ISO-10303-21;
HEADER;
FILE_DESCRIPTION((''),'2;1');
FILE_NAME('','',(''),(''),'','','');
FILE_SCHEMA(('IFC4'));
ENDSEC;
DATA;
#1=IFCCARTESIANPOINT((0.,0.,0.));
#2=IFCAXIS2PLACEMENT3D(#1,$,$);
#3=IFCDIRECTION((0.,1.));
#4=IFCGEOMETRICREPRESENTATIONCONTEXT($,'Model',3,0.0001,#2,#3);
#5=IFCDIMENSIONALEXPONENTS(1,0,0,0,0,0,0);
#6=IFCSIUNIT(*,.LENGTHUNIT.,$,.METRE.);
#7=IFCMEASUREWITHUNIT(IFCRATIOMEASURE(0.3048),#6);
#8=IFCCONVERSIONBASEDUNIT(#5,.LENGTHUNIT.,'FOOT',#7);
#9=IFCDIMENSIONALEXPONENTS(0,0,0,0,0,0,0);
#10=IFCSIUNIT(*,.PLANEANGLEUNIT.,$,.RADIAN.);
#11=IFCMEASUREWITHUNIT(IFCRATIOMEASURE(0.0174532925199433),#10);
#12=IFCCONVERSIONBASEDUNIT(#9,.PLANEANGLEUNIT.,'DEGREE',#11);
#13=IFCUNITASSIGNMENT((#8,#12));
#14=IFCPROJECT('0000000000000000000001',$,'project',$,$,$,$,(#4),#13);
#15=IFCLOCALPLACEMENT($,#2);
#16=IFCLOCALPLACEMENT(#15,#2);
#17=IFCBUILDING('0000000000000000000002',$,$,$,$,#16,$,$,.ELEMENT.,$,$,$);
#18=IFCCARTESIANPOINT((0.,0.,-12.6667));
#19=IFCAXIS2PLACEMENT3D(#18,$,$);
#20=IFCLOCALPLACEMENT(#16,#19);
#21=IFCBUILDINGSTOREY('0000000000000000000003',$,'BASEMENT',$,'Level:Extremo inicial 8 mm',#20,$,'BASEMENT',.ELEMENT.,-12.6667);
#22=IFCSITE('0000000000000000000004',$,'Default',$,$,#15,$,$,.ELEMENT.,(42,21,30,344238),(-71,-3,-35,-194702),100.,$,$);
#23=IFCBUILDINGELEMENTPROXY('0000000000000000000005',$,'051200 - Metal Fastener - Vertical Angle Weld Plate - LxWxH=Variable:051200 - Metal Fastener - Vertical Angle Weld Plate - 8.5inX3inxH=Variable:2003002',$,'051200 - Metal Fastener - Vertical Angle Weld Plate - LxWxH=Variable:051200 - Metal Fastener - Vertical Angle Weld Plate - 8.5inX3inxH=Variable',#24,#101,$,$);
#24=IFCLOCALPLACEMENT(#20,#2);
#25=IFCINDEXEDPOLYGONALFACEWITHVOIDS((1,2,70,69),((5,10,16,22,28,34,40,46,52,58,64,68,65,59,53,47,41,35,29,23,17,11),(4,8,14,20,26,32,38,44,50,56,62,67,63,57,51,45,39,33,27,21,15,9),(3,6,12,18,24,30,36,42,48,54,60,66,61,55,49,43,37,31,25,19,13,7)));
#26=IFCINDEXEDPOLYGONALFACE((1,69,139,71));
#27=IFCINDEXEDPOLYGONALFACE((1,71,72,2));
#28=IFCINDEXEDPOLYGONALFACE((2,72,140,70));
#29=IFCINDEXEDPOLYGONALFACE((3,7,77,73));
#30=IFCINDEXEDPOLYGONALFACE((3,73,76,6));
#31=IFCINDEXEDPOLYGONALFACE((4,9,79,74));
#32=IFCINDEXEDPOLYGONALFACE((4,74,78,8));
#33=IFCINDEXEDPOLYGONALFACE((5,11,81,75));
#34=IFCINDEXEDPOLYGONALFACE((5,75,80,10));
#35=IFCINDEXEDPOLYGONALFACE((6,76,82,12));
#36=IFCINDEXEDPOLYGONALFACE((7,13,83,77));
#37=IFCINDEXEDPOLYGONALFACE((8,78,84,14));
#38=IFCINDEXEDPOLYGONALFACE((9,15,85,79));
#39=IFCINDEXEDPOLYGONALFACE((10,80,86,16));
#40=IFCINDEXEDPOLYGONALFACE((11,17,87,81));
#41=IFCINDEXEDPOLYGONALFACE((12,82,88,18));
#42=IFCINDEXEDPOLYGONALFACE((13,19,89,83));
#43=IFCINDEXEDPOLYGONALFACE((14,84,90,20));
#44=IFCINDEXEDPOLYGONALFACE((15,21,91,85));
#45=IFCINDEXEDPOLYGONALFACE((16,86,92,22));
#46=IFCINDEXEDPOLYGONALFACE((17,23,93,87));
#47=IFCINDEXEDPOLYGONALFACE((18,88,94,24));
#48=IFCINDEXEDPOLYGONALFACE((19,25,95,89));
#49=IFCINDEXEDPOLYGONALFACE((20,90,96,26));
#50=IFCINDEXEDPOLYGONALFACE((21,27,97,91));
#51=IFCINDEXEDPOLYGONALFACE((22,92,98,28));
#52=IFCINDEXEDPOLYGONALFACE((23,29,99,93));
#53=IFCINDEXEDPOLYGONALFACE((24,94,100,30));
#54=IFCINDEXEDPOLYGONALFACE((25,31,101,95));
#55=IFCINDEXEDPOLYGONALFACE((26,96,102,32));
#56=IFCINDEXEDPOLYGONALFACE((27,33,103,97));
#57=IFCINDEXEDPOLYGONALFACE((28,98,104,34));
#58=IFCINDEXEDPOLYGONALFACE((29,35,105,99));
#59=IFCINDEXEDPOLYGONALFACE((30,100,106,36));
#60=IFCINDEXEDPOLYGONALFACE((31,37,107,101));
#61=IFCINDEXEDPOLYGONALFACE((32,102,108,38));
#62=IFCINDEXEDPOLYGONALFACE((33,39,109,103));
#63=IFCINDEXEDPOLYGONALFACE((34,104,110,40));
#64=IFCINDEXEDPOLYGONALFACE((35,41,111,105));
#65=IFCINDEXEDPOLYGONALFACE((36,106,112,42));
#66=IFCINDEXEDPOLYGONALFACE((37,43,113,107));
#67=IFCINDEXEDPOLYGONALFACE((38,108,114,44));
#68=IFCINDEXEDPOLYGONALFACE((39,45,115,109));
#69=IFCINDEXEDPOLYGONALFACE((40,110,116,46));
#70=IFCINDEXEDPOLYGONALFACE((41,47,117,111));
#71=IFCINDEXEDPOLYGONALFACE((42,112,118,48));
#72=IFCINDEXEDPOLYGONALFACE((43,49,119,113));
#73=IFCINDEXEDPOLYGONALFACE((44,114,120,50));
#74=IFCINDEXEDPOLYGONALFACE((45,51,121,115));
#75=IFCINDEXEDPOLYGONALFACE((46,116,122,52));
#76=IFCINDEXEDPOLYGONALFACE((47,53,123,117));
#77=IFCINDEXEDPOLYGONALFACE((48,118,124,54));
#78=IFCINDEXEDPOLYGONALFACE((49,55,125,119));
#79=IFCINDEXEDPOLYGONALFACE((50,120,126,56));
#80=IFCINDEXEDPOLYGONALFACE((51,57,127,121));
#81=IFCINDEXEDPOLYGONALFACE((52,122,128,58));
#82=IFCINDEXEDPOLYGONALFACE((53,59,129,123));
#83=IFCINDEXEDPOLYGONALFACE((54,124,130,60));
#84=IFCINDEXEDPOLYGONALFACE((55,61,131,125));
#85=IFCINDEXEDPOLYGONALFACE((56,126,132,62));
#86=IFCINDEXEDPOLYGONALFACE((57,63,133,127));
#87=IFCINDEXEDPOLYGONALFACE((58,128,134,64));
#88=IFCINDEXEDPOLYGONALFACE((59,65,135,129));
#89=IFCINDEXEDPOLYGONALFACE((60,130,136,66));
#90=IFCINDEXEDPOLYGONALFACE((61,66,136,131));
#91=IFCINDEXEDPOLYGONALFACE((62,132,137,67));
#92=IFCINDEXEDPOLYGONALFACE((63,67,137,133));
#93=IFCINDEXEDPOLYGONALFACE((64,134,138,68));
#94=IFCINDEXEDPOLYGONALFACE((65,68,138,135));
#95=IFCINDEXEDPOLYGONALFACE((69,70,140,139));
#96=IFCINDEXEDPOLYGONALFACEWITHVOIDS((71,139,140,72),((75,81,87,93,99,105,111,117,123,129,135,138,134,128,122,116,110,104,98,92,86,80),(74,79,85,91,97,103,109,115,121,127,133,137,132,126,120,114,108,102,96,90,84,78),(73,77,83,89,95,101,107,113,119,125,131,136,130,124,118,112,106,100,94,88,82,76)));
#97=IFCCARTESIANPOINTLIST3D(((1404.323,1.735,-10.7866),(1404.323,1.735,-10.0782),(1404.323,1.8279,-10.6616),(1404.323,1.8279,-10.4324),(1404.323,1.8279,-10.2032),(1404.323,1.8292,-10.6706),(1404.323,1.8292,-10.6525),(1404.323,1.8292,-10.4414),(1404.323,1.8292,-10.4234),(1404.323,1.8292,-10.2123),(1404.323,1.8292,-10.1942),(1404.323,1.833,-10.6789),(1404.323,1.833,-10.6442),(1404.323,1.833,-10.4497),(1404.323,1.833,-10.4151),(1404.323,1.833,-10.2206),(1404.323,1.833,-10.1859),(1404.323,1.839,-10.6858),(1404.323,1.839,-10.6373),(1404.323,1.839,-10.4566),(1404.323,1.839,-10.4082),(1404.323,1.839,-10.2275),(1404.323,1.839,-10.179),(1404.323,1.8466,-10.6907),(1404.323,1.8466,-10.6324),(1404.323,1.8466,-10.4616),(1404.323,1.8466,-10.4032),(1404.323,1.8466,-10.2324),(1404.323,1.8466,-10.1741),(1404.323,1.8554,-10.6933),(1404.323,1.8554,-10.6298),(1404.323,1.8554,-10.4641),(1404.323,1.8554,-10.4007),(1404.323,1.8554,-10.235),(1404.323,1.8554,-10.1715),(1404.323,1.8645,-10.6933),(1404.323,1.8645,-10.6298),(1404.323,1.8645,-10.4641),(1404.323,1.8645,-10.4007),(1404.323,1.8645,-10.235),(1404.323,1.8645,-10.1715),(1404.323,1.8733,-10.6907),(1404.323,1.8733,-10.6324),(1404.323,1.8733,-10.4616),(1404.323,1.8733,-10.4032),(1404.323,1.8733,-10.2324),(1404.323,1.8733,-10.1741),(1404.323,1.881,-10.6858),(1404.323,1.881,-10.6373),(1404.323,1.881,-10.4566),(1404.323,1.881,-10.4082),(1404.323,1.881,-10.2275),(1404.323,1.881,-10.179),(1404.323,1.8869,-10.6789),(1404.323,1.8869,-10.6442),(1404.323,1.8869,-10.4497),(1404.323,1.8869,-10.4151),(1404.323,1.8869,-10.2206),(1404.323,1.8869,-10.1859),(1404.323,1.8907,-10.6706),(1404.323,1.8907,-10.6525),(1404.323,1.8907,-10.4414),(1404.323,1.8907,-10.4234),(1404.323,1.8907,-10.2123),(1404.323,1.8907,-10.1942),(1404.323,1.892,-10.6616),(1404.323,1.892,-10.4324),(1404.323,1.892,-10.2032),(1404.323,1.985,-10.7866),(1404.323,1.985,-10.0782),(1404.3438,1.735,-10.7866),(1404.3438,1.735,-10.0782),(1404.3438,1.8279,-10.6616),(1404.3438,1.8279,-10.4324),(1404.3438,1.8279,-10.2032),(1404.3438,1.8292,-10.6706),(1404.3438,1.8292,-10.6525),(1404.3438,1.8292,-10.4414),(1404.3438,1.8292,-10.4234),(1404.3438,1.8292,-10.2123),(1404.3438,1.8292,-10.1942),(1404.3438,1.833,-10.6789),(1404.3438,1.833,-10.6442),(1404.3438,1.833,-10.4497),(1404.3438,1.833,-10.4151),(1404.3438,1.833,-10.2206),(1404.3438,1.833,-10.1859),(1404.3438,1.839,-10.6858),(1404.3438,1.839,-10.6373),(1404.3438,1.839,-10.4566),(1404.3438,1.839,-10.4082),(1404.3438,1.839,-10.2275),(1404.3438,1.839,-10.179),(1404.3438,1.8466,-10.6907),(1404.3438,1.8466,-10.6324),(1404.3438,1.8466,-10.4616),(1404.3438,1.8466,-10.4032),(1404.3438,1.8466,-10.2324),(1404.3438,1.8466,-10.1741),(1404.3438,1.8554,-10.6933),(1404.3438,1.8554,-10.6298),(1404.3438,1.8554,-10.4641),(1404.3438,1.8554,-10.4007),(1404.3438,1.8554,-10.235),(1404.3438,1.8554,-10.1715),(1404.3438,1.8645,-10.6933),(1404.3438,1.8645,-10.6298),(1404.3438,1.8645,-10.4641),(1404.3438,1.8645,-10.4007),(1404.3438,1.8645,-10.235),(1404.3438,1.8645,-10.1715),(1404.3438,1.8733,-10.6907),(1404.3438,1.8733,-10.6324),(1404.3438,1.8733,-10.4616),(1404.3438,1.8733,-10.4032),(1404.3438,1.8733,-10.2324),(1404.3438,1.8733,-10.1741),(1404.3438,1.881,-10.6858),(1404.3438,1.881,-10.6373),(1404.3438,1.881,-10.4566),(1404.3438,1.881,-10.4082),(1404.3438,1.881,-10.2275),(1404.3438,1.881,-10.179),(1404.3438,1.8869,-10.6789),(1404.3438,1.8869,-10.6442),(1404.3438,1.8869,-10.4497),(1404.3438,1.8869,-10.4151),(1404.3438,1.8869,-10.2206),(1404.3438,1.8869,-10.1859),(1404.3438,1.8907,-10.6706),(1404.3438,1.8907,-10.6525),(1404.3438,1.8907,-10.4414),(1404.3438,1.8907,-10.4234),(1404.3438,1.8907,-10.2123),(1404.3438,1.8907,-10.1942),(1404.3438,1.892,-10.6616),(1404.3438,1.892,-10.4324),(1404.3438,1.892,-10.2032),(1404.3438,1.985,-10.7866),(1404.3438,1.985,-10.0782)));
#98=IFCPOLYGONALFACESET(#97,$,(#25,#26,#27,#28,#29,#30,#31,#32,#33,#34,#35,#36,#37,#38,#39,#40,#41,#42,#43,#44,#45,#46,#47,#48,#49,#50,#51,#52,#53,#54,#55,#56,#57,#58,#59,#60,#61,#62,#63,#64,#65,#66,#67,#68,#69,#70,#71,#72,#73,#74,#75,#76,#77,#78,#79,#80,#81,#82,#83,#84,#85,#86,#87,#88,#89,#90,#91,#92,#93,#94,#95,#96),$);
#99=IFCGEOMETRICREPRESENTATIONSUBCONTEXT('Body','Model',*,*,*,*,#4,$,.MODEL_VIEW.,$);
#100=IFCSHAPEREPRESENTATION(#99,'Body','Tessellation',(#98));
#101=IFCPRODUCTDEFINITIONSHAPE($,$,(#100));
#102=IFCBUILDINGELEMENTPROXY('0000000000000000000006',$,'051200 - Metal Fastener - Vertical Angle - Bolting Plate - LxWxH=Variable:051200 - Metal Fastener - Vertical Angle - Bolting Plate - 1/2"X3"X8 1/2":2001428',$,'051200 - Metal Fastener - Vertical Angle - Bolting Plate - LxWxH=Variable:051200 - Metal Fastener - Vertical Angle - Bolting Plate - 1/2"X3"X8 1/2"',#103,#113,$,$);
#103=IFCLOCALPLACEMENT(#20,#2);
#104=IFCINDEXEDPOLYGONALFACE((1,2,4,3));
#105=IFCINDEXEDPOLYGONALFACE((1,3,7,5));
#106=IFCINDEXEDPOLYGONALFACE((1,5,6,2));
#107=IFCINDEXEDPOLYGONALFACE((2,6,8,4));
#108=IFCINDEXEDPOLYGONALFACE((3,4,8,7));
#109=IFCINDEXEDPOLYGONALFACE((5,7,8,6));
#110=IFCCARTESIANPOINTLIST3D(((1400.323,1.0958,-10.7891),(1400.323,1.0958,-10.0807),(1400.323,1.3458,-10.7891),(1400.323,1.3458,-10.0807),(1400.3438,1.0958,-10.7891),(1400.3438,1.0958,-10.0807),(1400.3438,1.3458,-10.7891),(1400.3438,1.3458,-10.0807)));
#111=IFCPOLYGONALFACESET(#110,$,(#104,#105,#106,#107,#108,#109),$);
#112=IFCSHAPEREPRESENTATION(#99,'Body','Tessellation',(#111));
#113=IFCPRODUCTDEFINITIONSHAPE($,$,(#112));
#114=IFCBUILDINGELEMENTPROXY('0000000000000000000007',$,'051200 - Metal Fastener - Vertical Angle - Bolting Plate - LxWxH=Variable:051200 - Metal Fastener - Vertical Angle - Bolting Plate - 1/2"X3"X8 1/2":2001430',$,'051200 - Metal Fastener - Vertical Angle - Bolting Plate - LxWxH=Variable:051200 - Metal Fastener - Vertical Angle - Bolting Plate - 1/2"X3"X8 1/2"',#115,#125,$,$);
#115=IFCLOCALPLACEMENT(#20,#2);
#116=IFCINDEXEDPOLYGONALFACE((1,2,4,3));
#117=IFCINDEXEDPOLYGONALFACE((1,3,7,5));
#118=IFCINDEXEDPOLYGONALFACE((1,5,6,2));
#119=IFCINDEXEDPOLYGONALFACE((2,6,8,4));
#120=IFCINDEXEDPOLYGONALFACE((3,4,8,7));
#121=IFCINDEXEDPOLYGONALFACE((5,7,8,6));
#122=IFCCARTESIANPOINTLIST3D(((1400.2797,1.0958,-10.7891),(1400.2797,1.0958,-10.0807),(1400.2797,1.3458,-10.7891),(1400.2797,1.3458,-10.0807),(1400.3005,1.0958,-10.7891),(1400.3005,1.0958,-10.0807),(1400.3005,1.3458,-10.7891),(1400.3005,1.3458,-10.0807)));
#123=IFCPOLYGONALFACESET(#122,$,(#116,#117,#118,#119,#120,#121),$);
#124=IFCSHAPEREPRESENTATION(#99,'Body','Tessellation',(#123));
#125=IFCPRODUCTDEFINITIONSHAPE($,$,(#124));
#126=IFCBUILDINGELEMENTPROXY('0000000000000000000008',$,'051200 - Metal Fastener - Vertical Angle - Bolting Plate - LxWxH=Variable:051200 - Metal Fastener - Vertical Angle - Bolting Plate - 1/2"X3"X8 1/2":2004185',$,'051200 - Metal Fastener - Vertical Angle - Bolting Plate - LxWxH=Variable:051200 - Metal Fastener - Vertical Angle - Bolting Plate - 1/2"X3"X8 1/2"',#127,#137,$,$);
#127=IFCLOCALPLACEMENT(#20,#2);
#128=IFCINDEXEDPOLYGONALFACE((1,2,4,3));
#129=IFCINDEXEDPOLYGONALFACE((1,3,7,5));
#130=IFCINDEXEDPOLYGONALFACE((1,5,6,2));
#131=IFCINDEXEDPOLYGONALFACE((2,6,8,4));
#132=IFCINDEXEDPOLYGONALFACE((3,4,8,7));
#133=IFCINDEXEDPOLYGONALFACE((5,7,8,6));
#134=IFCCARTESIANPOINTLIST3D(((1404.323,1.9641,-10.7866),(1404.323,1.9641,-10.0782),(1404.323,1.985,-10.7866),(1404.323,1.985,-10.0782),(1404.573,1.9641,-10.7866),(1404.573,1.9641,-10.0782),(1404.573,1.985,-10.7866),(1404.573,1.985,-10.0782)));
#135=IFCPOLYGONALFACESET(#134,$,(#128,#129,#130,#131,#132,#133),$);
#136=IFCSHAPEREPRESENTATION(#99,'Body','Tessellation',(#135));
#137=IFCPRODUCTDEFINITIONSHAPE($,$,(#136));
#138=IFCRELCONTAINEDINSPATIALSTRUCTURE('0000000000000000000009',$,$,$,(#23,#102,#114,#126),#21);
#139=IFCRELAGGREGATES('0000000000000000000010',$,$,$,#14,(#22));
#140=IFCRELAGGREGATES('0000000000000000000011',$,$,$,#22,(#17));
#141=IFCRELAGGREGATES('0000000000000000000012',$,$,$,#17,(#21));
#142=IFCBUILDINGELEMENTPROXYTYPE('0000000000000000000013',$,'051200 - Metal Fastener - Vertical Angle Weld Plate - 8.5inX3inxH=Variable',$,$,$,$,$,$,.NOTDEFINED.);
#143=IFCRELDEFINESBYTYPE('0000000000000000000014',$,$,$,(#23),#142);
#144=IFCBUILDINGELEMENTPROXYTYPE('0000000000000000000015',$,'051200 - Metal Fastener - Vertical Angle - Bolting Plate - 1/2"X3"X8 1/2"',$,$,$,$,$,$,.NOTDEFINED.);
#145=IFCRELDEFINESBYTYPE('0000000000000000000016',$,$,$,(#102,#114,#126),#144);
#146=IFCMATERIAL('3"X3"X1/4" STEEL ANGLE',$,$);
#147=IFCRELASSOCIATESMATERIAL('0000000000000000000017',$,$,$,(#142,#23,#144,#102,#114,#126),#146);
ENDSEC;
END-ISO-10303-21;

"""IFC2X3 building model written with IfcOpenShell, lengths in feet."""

from ifc_helpers import new_model, entity, si_unit, converted_unit, direction, frame, frame_2d, origin, origin_2d_with_axis, place, context, subcontext, project, spatial, polyline, circle_curve, parameter, trimmed, segment, composite_curve, rectangle, outline, extrude, source, transform, mapped, material, type_object, type_shapes, element, save


model = new_model("IFC2X3")

# Units and contexts
model_context = context("Model", 3, precision=0.0001, world=origin(), true_north=direction((0.0, 1.0)))
body_context = subcontext(model_context, "Body", "Model", "MODEL_VIEW")
ifc_project = project(units=[converted_unit("LENGTHUNIT", "FOOT", entity("IfcRatioMeasure", 0.3048), si_unit("LENGTHUNIT", "METRE"), dimensions=[1, 0, 0, 0, 0, 0, 0]), converted_unit("PLANEANGLEUNIT", "DEGREE", entity("IfcRatioMeasure", 0.0174532925199433), si_unit("PLANEANGLEUNIT", "RADIAN"), dimensions=[0, 0, 0, 0, 0, 0, 0])], contexts=[model_context])

# Site, building, storey
site_placement = place(None, origin())
site = spatial("IfcSite", under=ifc_project, at=site_placement, Name="Default", CompositionType="ELEMENT", RefLatitude=(42, 21, 30, 344238), RefLongitude=(-71, -3, -35, -194702), RefElevation=100.0)
building_placement = place(site_placement, origin())
building = spatial("IfcBuilding", under=site, at=building_placement, CompositionType="ELEMENT")
storey_placement = place(building_placement, frame((0.0, 0.0, -12.6667)))
storey = spatial("IfcBuildingStorey", under=building, at=storey_placement, Name="BASEMENT", ObjectType="Level:Extremo inicial 8 mm", LongName="BASEMENT", CompositionType="ELEMENT", Elevation=-12.6667)

# Building element proxies
ifc_material_1 = material(Name="3\"X3\"X1/4\" STEEL ANGLE")
building_element_proxy_type_1 = type_object("IfcBuildingElementProxyType", Name="051200 - Metal Fastener - Vertical Angle Weld Plate - 8.5inX3inxH=Variable", PredefinedType="NOTDEFINED", material=ifc_material_1)
shared_shape_1 = source(origin(), body_context, "Body", "SweptSolid", [
    extrude(outline(polyline([(-0.125, -0.3542), (0.125, -0.3542), (0.125, 0.3542), (-0.125, 0.3542), (-0.125, -0.3542)]), holes=[composite_curve([segment(trimmed(circle_curve(frame_2d((0.0, -0.2292), x_axis=(-1.0, 0.0)), 0.0321), [parameter(180.0)], [parameter(0.0)], True, "PARAMETER"), False, "CONTINUOUS"), segment(trimmed(circle_curve(frame_2d((0.0, -0.2292), x_axis=(-1.0, 0.0)), 0.0321), [parameter(0.0)], [parameter(180.0)], True, "PARAMETER"), False, "CONTINUOUS")], self_intersect=False), composite_curve([segment(trimmed(circle_curve(frame_2d((0.0, 0.0), x_axis=(-1.0, 0.0)), 0.0321), [parameter(180.0)], [parameter(0.0)], True, "PARAMETER"), False, "CONTINUOUS"), segment(trimmed(circle_curve(frame_2d((0.0, 0.0), x_axis=(-1.0, 0.0)), 0.0321), [parameter(0.0)], [parameter(180.0)], True, "PARAMETER"), False, "CONTINUOUS")], self_intersect=False), composite_curve([segment(trimmed(circle_curve(frame_2d((0.0, 0.2292), x_axis=(-1.0, 0.0)), 0.0321), [parameter(180.0)], [parameter(0.0)], True, "PARAMETER"), False, "CONTINUOUS"), segment(trimmed(circle_curve(frame_2d((0.0, 0.2292), x_axis=(-1.0, 0.0)), 0.0321), [parameter(0.0)], [parameter(180.0)], True, "PARAMETER"), False, "CONTINUOUS")], self_intersect=False)]), frame((0.0, 0.0, 0.0), z_axis=(0.0, 0.0, 1.0), x_axis=(-1.0, 0.0, 0.0)), (0.0, 0.0, 1.0), 0.0208),
])
type_shapes(building_element_proxy_type_1, [shared_shape_1])
for number, where, z_axis, x_axis, name in (
    (1, (1404.323, 1.86, -10.4324), (1.0, 0.0, 0.0), (0.0, 1.0, 0.0), "051200 - Metal Fastener - Vertical Angle Weld Plate - LxWxH=Variable:051200 - Metal Fastener - Vertical Angle Weld Plate - 8.5inX3inxH=Variable:2003002"),
):
    element("IfcBuildingElementProxy", number, at=place(storey_placement, frame(where, z_axis=z_axis, x_axis=x_axis)), inside=storey, type_object=building_element_proxy_type_1, material=ifc_material_1, Name=name, ObjectType="051200 - Metal Fastener - Vertical Angle Weld Plate - LxWxH=Variable:051200 - Metal Fastener - Vertical Angle Weld Plate - 8.5inX3inxH=Variable", context=body_context, shape_type="MappedRepresentation", body=[
        mapped(shared_shape_1, transform((0.0, 0.0, 0.0), scale=1.0)),
    ])
building_element_proxy_type_2 = type_object("IfcBuildingElementProxyType", Name="051200 - Metal Fastener - Vertical Angle - Bolting Plate - 1/2\"X3\"X8 1/2\"", PredefinedType="NOTDEFINED", material=ifc_material_1)
shared_shape_2 = source(origin(), body_context, "Body", "SweptSolid", [
    extrude(rectangle(XDim=0.25, YDim=0.7083, at=origin_2d_with_axis()), frame((0.0, 0.0, 0.0), z_axis=(0.0, 0.0, 1.0), x_axis=(-1.0, 0.0, 0.0)), (0.0, 0.0, 1.0), 0.0208),
])
type_shapes(building_element_proxy_type_2, [shared_shape_2])
for number, where, z_axis, x_axis, name in (
    (2, (1400.323, 1.2208, -10.4349), (1.0, 0.0, 0.0), (0.0, 1.0, 0.0), "051200 - Metal Fastener - Vertical Angle - Bolting Plate - LxWxH=Variable:051200 - Metal Fastener - Vertical Angle - Bolting Plate - 1/2\"X3\"X8 1/2\":2001428"),
    (3, (1400.3005, 1.2208, -10.4349), (-1.0, 0.0, 0.0), (0.0, -1.0, 0.0), "051200 - Metal Fastener - Vertical Angle - Bolting Plate - LxWxH=Variable:051200 - Metal Fastener - Vertical Angle - Bolting Plate - 1/2\"X3\"X8 1/2\":2001430"),
    (4, (1404.448, 1.985, -10.4324), (0.0, -1.0, 0.0), (1.0, 0.0, 0.0), "051200 - Metal Fastener - Vertical Angle - Bolting Plate - LxWxH=Variable:051200 - Metal Fastener - Vertical Angle - Bolting Plate - 1/2\"X3\"X8 1/2\":2004185"),
):
    element("IfcBuildingElementProxy", number, at=place(storey_placement, frame(where, z_axis=z_axis, x_axis=x_axis)), inside=storey, type_object=building_element_proxy_type_2, material=ifc_material_1, Name=name, ObjectType="051200 - Metal Fastener - Vertical Angle - Bolting Plate - LxWxH=Variable:051200 - Metal Fastener - Vertical Angle - Bolting Plate - 1/2\"X3\"X8 1/2\"", context=body_context, shape_type="MappedRepresentation", body=[
        mapped(shared_shape_2, transform((0.0, 0.0, 0.0), scale=1.0)),
    ])

save(model, "model.ifc")
